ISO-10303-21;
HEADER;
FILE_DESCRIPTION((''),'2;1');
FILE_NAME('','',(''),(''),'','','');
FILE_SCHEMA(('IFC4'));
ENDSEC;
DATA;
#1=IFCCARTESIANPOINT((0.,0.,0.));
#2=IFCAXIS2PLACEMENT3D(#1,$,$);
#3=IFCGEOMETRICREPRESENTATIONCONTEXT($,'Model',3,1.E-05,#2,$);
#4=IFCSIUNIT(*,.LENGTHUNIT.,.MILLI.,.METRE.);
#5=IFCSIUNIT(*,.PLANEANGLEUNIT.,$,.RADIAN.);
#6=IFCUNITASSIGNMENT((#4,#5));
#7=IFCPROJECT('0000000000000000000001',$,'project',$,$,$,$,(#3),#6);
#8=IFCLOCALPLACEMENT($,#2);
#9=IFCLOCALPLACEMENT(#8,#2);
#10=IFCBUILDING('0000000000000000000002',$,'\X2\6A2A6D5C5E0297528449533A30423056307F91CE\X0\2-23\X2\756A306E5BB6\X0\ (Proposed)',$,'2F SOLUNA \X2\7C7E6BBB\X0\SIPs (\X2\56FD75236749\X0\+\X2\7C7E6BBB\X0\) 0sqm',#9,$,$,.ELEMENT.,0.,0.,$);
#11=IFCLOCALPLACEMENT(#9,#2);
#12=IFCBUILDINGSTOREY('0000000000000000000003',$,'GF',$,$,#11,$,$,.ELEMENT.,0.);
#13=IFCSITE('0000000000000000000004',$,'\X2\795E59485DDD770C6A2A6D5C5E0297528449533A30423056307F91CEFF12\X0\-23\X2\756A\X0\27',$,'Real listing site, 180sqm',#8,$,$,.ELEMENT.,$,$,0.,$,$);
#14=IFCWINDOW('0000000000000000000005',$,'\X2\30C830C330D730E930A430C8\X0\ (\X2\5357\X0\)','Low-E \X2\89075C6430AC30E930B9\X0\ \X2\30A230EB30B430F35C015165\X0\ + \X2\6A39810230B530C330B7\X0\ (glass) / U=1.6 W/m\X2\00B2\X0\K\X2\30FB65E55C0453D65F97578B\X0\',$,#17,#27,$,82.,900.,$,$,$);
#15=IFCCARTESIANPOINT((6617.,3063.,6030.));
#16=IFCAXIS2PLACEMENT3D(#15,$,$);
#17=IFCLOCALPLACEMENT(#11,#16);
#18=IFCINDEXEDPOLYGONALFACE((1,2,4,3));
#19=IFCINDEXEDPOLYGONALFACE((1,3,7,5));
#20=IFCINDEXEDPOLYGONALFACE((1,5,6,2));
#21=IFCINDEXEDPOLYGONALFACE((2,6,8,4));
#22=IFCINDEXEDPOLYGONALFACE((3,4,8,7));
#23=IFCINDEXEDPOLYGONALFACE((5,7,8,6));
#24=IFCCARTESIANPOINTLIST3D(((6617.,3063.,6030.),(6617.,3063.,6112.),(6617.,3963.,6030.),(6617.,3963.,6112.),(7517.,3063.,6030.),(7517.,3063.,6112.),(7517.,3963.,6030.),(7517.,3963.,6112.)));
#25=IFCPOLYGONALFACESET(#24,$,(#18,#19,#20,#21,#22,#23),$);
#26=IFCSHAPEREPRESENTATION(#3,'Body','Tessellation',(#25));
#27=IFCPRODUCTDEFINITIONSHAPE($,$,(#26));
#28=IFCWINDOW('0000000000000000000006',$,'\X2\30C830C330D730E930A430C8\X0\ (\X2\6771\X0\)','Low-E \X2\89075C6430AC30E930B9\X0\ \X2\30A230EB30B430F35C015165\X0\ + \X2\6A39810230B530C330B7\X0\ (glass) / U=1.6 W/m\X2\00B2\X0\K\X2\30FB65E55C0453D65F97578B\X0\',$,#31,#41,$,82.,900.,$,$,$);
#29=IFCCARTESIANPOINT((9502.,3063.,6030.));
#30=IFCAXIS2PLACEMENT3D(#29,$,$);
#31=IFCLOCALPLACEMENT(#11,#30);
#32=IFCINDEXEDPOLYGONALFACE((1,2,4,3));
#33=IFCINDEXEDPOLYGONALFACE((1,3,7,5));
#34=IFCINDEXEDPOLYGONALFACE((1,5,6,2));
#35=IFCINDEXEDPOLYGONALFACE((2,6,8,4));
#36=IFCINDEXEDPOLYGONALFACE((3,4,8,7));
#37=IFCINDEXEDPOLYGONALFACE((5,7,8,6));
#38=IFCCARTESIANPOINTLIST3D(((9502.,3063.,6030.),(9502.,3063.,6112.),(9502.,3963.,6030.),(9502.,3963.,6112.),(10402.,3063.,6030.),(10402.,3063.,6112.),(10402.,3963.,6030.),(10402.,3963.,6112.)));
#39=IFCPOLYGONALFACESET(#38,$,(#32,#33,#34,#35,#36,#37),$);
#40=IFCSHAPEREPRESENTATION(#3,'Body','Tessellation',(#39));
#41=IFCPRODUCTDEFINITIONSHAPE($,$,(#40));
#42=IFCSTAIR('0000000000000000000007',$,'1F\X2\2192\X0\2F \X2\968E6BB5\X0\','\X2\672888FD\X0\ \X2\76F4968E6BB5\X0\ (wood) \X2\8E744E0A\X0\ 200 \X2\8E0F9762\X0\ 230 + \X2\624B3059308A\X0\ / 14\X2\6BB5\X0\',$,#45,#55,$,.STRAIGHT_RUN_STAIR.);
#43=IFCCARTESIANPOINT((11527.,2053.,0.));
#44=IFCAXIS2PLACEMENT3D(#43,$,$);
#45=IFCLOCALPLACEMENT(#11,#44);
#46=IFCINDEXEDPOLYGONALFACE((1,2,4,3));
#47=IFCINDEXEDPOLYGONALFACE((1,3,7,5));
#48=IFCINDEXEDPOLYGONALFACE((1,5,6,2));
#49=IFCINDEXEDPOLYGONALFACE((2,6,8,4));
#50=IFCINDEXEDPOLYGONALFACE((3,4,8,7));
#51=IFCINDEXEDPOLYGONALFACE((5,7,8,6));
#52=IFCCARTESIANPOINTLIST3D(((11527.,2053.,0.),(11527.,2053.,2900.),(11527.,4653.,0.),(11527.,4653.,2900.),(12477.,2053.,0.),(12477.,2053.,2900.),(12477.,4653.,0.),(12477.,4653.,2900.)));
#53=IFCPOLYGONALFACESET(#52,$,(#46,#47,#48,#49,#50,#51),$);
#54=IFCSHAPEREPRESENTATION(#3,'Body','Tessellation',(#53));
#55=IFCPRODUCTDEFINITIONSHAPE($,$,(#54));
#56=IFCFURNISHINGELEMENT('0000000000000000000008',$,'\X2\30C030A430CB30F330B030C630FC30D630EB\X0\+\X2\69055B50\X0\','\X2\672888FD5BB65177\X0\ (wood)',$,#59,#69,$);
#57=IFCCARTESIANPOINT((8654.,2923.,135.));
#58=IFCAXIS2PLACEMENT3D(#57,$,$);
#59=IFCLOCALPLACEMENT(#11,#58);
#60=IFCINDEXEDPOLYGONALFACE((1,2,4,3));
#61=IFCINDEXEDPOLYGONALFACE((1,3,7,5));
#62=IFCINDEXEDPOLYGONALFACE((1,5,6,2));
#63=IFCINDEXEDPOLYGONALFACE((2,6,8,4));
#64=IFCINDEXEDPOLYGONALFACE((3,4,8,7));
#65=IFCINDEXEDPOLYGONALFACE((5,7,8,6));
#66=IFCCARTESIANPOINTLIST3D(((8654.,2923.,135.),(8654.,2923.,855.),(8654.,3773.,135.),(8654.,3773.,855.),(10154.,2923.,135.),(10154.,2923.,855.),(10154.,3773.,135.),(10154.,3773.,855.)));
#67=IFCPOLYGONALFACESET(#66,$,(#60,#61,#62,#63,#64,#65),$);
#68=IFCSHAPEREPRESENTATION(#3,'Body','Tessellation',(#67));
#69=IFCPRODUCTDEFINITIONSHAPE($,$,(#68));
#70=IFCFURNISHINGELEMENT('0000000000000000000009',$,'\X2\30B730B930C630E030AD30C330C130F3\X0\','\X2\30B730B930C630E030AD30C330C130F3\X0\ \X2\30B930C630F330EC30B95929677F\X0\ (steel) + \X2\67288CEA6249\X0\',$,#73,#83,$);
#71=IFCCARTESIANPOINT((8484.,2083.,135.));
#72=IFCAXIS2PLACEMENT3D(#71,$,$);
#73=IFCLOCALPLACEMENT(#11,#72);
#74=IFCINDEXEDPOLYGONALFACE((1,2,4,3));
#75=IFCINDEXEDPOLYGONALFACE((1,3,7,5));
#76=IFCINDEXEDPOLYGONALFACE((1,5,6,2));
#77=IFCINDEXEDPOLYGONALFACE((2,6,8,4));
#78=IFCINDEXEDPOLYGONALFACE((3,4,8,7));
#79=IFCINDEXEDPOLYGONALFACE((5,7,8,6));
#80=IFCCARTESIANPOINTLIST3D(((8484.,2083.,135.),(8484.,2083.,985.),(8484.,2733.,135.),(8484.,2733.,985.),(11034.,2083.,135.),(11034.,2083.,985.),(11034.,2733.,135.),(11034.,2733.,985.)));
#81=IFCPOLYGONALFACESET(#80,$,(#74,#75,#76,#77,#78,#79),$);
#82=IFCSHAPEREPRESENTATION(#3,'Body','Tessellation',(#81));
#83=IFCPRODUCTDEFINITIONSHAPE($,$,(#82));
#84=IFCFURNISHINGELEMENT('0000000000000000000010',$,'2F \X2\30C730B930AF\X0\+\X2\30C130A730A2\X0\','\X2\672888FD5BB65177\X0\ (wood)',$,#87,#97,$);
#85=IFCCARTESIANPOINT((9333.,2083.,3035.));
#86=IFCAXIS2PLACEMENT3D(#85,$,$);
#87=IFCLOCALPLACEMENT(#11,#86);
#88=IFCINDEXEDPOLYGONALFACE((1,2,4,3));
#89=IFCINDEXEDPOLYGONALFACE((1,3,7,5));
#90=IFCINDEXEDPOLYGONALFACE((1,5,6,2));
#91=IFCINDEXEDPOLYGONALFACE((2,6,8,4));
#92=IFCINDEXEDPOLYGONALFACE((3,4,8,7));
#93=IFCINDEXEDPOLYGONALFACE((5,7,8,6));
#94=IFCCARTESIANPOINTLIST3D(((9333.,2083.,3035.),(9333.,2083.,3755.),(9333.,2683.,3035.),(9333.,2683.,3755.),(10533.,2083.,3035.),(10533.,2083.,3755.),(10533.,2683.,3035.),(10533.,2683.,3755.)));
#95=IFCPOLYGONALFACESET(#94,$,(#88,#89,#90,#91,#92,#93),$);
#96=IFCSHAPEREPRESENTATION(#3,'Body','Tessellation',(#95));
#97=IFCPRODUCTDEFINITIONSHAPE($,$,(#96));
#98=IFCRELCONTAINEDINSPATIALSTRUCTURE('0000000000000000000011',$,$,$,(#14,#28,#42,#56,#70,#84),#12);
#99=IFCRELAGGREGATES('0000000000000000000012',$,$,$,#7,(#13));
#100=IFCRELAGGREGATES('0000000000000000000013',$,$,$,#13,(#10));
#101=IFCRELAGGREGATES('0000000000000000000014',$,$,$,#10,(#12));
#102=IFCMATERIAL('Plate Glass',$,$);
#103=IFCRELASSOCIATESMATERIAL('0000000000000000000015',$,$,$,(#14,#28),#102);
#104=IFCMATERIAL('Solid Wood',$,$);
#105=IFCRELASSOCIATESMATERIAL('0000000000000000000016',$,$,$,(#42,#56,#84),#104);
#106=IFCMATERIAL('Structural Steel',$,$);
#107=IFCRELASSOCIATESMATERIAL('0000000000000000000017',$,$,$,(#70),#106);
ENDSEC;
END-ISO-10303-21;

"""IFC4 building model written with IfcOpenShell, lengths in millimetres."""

from ifc_helpers import new_model, si_unit, frame, frame_2d, origin, place, context, project, spatial, rectangle, extrude, material, element, save


model = new_model("IFC4")

# Units and contexts
model_context = context("Model", 3, precision=1e-05, world=origin())
ifc_project = project(units=[si_unit("LENGTHUNIT", "METRE", prefix="MILLI"), si_unit("PLANEANGLEUNIT", "RADIAN")], contexts=[model_context])

# Site, building, storey
site_placement = place(None, origin())
site = spatial("IfcSite", under=ifc_project, at=site_placement, Name="神奈川県横浜市青葉区あざみ野２-23番27", ObjectType="Real listing site, 180sqm", CompositionType="ELEMENT", RefElevation=0.0)
building_placement = place(site_placement, origin())
building = spatial("IfcBuilding", under=site, at=building_placement, Name="横浜市青葉区あざみ野2-23番の家 (Proposed)", ObjectType="2F SOLUNA 籾殻SIPs (国産杉+籾殻) 0sqm", CompositionType="ELEMENT", ElevationOfRefHeight=0.0, ElevationOfTerrain=0.0)
storey_placement = place(building_placement, origin())
storey = spatial("IfcBuildingStorey", under=building, at=storey_placement, Name="GF", CompositionType="ELEMENT", Elevation=0.0)

# Shared definitions
ifc_material_1 = material(Name="Solid Wood")

# Shared definitions
ifc_material_2 = material(Name="Plate Glass")

# Windows
window_1_placement = place(storey_placement, frame((6617.0, 3063.0, 6030.0)))
element("IfcWindow", 1, at=window_1_placement, inside=storey, material=ifc_material_2, Name="トップライト (南)", Description="Low-E 複層ガラス アルゴン封入 + 樹脂サッシ (glass) / U=1.6 W/m²K・日射取得型", OverallHeight=82.0, OverallWidth=900.0, context=model_context, shape_type="SweptSolid", body=[
    extrude(rectangle(XDim=900.0, YDim=900.0, at=frame_2d((450.0, 450.0))), frame((6617.0, 3063.0, 6030.0)), (0.0, 0.0, 1.0), 82.0),
])
window_2_placement = place(storey_placement, frame((9502.0, 3063.0, 6030.0)))
element("IfcWindow", 2, at=window_2_placement, inside=storey, material=ifc_material_2, Name="トップライト (東)", Description="Low-E 複層ガラス アルゴン封入 + 樹脂サッシ (glass) / U=1.6 W/m²K・日射取得型", OverallHeight=82.0, OverallWidth=900.0, context=model_context, shape_type="SweptSolid", body=[
    extrude(rectangle(XDim=900.0, YDim=900.0, at=frame_2d((450.0, 450.0))), frame((9502.0, 3063.0, 6030.0)), (0.0, 0.0, 1.0), 82.0),
])

# Stair
stair_placement = place(storey_placement, frame((11527.0, 2053.0, 0.0)))
element("IfcStair", 3, at=stair_placement, inside=storey, material=ifc_material_1, Name="1F→2F 階段", Description="木製 直階段 (wood) 蹴上 200 踏面 230 + 手すり / 14段", PredefinedType="STRAIGHT_RUN_STAIR", context=model_context, shape_type="SweptSolid", body=[
    extrude(rectangle(XDim=950.0, YDim=2600.0, at=frame_2d((475.0, 1300.0))), frame((11527.0, 2053.0, 0.0)), (0.0, 0.0, 1.0), 2900.0),
])

# Furnishing elements
furnishing_1_placement = place(storey_placement, frame((8654.0, 2923.0, 135.0)))
element("IfcFurnishingElement", 4, at=furnishing_1_placement, inside=storey, material=ifc_material_1, Name="ダイニングテーブル+椅子", Description="木製家具 (wood)", context=model_context, shape_type="SweptSolid", body=[
    extrude(rectangle(XDim=1500.0, YDim=850.0, at=frame_2d((750.0, 425.0))), frame((8654.0, 2923.0, 135.0)), (0.0, 0.0, 1.0), 720.0),
])
ifc_material_3 = material(Name="Structural Steel")
furnishing_2_placement = place(storey_placement, frame((8484.0, 2083.0, 135.0)))
element("IfcFurnishingElement", 5, at=furnishing_2_placement, inside=storey, material=ifc_material_3, Name="システムキッチン", Description="システムキッチン ステンレス天板 (steel) + 木質扉", context=model_context, shape_type="SweptSolid", body=[
    extrude(rectangle(XDim=2550.0, YDim=650.0, at=frame_2d((1275.0, 325.0))), frame((8484.0, 2083.0, 135.0)), (0.0, 0.0, 1.0), 850.0),
])
furnishing_3_placement = place(storey_placement, frame((9333.0, 2083.0, 3035.0)))
element("IfcFurnishingElement", 6, at=furnishing_3_placement, inside=storey, material=ifc_material_1, Name="2F デスク+チェア", Description="木製家具 (wood)", context=model_context, shape_type="SweptSolid", body=[
    extrude(rectangle(XDim=1200.0, YDim=600.0, at=frame_2d((600.0, 300.0))), frame((9333.0, 2083.0, 3035.0)), (0.0, 0.0, 1.0), 720.0),
])

save(model, "model.ifc")
